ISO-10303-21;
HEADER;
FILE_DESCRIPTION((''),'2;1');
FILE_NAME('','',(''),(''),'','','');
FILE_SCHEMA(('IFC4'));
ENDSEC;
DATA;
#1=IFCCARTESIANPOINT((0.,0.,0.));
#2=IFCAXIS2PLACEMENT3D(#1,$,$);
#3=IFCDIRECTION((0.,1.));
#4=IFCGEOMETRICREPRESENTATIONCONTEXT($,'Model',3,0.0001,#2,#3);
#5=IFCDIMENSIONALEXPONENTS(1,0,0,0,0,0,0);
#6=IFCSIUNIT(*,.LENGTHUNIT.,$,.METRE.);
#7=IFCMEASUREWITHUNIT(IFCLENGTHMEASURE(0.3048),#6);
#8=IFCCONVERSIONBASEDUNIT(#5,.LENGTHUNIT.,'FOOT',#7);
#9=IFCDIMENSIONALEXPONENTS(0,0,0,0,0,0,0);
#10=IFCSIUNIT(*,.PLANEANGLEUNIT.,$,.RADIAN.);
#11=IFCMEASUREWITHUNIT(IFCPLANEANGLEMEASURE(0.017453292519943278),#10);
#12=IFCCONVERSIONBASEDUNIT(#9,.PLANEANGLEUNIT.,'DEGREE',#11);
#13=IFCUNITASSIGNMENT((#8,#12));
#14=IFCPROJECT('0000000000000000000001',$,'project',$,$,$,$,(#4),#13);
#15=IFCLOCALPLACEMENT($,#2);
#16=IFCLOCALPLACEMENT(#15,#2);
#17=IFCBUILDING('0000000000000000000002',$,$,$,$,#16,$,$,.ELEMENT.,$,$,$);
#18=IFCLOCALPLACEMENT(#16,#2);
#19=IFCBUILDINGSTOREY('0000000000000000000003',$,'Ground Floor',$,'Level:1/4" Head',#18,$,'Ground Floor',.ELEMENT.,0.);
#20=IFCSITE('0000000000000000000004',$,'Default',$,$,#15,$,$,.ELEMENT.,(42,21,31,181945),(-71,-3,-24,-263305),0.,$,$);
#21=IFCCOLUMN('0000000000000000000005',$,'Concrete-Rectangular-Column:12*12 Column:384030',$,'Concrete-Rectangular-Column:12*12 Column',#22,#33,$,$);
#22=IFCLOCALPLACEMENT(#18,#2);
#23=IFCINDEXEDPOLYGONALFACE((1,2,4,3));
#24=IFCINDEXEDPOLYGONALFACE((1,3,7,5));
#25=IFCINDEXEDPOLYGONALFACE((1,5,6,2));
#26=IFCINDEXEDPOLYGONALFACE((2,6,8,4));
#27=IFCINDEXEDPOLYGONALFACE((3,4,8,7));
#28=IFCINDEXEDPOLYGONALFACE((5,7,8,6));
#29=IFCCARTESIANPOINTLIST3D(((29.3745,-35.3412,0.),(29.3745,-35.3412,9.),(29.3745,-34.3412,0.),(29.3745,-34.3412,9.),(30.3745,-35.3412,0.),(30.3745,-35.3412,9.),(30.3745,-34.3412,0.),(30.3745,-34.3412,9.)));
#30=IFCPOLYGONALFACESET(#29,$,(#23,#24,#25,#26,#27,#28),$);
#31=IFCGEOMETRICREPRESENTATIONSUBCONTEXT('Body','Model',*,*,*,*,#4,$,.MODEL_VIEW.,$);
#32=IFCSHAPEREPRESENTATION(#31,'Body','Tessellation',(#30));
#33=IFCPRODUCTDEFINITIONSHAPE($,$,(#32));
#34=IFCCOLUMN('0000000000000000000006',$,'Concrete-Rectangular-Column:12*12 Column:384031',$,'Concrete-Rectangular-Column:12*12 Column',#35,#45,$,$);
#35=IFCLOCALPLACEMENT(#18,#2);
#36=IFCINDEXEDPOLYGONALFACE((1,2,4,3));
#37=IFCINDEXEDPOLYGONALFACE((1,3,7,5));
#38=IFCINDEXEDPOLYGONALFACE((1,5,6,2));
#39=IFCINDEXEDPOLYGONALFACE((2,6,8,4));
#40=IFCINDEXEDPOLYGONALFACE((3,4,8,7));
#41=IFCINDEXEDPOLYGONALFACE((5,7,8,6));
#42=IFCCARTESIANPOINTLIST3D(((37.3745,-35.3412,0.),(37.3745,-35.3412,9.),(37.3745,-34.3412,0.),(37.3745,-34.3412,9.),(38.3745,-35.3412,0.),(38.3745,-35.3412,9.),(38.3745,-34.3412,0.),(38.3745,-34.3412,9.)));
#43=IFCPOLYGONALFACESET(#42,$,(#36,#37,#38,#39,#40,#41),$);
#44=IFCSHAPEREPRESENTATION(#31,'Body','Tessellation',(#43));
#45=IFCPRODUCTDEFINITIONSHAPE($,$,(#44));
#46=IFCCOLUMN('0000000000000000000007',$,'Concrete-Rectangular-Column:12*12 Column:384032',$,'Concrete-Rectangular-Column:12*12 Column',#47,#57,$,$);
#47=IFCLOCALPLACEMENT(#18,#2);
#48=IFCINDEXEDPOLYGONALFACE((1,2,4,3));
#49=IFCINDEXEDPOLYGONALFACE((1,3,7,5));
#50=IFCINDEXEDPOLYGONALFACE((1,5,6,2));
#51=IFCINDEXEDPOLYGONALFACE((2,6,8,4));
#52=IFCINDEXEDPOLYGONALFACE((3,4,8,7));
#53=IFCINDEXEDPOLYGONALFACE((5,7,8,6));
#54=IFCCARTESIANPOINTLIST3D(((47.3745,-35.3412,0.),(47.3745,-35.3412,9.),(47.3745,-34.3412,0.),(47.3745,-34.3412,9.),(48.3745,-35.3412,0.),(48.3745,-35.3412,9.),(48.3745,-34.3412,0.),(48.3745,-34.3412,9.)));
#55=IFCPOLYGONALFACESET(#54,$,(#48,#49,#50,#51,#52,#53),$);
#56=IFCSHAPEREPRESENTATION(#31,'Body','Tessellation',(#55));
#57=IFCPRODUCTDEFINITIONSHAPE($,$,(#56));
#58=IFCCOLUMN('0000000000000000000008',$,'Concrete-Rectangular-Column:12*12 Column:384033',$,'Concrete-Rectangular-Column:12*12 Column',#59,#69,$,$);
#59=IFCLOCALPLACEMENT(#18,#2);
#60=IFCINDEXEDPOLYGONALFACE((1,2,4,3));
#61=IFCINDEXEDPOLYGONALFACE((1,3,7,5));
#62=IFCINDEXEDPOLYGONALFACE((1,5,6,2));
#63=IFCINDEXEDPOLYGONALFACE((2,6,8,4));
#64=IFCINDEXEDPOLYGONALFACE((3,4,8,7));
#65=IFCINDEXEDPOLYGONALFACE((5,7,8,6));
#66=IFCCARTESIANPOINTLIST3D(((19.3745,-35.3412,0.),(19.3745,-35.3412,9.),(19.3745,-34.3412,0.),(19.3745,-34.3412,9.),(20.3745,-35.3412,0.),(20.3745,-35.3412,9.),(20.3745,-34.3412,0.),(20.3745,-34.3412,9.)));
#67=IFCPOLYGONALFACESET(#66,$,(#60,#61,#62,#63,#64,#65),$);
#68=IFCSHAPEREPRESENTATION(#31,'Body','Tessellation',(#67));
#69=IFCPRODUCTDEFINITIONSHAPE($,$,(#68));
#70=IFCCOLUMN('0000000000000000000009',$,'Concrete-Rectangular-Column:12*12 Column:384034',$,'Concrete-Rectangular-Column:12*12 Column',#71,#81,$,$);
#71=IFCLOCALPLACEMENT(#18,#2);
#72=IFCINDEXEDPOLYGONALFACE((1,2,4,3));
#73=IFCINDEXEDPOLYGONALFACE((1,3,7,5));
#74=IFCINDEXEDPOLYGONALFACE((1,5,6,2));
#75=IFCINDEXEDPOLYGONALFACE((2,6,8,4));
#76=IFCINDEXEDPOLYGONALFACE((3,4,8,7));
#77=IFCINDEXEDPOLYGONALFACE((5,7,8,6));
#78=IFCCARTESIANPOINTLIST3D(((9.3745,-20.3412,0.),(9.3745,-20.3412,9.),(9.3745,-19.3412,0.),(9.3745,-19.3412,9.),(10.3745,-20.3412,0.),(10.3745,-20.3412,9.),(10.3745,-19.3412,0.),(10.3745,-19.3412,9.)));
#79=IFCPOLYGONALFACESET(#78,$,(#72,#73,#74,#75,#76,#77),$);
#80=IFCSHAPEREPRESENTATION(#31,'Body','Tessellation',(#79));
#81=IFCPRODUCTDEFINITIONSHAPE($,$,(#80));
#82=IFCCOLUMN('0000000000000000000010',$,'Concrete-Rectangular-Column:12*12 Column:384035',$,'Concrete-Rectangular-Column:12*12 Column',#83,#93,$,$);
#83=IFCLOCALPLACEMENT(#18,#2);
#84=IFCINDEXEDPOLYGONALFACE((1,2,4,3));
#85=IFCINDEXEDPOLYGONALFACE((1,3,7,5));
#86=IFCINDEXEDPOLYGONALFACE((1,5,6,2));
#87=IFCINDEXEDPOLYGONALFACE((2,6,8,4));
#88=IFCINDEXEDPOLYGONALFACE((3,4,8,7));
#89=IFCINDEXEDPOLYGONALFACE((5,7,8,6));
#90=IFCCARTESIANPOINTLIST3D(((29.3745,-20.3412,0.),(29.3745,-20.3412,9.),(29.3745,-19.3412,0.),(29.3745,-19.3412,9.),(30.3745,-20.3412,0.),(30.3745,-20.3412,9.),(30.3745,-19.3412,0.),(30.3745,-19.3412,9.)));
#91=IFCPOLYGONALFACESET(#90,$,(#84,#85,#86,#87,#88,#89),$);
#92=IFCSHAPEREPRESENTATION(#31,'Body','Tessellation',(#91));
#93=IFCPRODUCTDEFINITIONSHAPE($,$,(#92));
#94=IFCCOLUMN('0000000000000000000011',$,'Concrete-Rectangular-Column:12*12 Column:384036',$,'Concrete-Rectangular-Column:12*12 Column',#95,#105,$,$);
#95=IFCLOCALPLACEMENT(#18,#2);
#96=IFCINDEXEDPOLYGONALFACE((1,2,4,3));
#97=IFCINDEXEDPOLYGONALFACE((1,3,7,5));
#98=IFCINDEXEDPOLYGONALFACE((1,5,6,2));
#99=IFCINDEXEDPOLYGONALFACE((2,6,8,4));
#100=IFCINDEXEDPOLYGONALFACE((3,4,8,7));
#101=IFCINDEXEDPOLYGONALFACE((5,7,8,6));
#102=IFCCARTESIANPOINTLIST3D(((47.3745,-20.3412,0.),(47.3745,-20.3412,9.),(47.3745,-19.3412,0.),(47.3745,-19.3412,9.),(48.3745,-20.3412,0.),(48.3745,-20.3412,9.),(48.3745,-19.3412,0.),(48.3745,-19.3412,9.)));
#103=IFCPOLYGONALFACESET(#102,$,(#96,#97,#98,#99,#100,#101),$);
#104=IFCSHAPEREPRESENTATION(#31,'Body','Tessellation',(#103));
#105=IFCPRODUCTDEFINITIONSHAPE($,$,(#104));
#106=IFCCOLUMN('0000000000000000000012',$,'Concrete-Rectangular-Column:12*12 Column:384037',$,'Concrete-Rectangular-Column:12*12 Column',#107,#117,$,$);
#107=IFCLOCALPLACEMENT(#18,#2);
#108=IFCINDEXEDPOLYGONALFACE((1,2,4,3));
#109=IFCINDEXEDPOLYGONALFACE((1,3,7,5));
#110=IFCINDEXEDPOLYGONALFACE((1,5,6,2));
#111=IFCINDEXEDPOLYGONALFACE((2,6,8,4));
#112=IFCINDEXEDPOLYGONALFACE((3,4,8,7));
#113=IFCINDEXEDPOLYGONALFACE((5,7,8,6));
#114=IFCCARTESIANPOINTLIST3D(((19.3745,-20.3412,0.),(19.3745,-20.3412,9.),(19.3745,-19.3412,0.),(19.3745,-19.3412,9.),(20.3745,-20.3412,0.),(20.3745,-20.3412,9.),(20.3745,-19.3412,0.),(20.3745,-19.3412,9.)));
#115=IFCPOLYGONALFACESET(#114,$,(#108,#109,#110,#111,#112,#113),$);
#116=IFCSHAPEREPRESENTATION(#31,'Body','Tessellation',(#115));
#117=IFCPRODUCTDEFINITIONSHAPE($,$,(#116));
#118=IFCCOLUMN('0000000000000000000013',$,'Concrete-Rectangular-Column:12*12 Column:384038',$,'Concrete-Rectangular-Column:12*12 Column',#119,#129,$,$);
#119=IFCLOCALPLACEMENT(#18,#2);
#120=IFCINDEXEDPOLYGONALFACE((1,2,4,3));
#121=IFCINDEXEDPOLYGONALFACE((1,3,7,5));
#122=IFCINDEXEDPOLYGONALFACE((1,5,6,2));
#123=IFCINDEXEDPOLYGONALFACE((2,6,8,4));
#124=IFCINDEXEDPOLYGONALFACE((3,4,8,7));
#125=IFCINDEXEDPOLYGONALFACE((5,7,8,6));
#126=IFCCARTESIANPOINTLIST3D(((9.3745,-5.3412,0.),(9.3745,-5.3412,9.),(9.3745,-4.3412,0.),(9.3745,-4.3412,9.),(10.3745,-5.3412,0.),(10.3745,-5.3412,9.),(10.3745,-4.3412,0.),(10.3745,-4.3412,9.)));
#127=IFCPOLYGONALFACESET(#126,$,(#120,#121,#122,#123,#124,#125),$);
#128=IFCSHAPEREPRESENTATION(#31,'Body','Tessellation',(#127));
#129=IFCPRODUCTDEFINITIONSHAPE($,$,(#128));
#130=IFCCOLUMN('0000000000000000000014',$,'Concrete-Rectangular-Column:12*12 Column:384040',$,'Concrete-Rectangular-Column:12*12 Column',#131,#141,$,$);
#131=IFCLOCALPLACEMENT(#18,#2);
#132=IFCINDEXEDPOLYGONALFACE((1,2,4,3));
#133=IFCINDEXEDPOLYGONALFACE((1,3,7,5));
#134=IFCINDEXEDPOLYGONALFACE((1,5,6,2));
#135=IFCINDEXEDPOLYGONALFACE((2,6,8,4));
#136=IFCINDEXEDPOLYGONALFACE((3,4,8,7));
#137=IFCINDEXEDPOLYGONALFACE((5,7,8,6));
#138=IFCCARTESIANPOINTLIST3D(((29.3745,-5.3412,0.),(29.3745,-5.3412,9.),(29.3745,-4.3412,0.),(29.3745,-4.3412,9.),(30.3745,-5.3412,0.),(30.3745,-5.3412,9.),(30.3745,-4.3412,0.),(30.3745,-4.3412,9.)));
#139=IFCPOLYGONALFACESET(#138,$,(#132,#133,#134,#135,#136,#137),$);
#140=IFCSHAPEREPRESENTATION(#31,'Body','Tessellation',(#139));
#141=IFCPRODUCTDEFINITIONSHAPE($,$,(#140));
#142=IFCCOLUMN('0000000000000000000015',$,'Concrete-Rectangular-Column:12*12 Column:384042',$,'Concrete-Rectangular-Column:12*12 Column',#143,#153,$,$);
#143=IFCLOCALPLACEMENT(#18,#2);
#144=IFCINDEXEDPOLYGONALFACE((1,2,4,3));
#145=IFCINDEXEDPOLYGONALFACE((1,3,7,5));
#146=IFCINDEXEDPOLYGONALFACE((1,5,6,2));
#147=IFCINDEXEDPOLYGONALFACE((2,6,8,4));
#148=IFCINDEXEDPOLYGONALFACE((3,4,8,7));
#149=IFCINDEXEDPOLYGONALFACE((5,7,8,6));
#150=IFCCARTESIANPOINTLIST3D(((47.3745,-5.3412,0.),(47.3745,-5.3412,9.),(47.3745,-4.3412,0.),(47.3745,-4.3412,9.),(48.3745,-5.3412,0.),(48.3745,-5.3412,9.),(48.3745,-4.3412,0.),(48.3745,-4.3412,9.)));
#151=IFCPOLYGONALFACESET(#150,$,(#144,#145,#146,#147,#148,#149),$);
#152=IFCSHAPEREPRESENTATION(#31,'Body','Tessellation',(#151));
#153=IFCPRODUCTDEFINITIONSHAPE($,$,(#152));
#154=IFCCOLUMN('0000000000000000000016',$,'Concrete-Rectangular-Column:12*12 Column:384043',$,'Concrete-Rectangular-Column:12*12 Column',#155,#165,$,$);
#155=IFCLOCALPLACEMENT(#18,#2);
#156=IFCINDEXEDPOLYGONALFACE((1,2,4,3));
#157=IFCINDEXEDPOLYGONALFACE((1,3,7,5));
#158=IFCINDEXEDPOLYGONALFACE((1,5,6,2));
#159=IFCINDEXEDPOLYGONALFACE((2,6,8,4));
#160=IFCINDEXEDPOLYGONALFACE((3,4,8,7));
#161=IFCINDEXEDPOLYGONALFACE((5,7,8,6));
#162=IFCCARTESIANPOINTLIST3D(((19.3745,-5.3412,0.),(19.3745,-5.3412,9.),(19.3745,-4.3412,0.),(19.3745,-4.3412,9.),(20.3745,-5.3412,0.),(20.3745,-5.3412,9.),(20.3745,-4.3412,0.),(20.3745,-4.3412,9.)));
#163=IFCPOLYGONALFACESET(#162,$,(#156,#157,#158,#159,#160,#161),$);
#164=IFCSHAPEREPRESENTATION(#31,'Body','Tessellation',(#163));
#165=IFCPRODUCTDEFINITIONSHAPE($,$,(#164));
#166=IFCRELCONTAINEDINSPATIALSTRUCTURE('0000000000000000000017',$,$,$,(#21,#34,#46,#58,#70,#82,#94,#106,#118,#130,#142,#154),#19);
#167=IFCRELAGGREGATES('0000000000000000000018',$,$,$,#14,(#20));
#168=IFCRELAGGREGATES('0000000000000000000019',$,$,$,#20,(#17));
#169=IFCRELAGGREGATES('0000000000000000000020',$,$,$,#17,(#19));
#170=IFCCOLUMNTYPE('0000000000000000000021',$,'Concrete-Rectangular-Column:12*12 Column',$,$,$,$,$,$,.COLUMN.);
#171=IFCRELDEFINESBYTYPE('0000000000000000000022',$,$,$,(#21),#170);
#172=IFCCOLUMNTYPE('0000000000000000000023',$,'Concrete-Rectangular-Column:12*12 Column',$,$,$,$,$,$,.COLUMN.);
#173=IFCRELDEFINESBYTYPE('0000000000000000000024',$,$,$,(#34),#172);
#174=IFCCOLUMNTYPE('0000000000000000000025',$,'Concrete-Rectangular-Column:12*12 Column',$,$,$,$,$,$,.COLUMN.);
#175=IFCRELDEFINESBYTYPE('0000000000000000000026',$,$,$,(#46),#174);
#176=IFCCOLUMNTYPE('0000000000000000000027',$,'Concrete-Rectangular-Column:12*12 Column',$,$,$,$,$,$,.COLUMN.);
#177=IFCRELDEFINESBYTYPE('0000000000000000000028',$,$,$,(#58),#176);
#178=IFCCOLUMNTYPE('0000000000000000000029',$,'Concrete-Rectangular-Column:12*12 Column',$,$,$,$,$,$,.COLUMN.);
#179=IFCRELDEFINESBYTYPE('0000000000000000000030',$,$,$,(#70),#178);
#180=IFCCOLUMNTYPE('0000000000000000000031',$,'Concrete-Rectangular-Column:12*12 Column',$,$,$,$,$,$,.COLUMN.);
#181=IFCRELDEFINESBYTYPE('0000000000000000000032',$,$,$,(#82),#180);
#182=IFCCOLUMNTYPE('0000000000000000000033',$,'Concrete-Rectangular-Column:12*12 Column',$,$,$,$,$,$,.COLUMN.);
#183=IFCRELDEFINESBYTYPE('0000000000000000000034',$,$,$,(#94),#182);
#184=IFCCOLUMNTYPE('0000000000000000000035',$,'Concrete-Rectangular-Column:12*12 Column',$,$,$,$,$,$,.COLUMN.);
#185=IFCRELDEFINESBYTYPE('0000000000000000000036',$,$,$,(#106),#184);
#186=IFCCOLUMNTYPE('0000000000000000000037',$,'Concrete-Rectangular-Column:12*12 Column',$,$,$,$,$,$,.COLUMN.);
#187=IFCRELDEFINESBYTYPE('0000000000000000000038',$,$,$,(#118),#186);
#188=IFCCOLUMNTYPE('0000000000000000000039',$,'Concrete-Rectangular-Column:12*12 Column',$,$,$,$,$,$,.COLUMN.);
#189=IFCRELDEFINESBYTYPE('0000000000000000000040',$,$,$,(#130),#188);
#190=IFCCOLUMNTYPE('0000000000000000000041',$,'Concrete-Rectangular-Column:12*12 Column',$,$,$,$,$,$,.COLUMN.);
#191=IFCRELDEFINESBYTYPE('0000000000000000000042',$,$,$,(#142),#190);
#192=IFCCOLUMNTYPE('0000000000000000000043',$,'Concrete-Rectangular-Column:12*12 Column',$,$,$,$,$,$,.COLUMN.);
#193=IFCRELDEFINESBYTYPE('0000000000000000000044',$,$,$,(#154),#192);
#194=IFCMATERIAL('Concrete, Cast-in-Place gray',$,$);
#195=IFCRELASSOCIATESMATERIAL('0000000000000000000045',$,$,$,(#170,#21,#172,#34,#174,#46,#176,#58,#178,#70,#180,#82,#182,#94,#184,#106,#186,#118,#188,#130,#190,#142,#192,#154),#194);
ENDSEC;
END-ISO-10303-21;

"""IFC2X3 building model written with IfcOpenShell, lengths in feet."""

from ifc_helpers import new_model, entity, si_unit, converted_unit, direction, frame, frame_2d, origin, origin_2d_with_axis, place, context, subcontext, project, spatial, rectangle, extrude, source, transform, mapped, material, type_object, type_shapes, element, save


model = new_model("IFC2X3")

# Units and contexts
model_context = context("Model", 3, precision=0.0001, world=origin(), true_north=direction((0.0, 1.0)))
body_context = subcontext(model_context, "Body", "Model", "MODEL_VIEW")
ifc_project = project(units=[converted_unit("LENGTHUNIT", "FOOT", entity("IfcLengthMeasure", 0.3048), si_unit("LENGTHUNIT", "METRE"), dimensions=[1, 0, 0, 0, 0, 0, 0]), converted_unit("PLANEANGLEUNIT", "DEGREE", entity("IfcPlaneAngleMeasure", 0.017453292519943278), si_unit("PLANEANGLEUNIT", "RADIAN"), dimensions=[0, 0, 0, 0, 0, 0, 0])], contexts=[model_context])

# Site, building, storey
site_placement = place(None, origin())
site = spatial("IfcSite", under=ifc_project, at=site_placement, Name="Default", CompositionType="ELEMENT", RefLatitude=(42, 21, 31, 181945), RefLongitude=(-71, -3, -24, -263305), RefElevation=0.0)
building_placement = place(site_placement, origin())
building = spatial("IfcBuilding", under=site, at=building_placement, CompositionType="ELEMENT")
storey_placement = place(building_placement, origin())
storey = spatial("IfcBuildingStorey", under=building, at=storey_placement, Name="Ground Floor", ObjectType="Level:1/4\" Head", LongName="Ground Floor", CompositionType="ELEMENT", Elevation=0.0)

# Columns
ifc_material_1 = material(Name="Concrete, Cast-in-Place gray")
column_type_1 = type_object("IfcColumnType", Name="Concrete-Rectangular-Column:12*12 Column", PredefinedType="COLUMN", material=ifc_material_1)
shared_shape_1 = source(origin(), body_context, "Body", "SweptSolid", [
    extrude(rectangle(XDim=1.0, YDim=1.0, at=frame_2d((0.0, 0.0), x_axis=(1.0, 0.0))), frame((29.8745, -34.8412, 0.0), z_axis=(0.0, 0.0, 1.0), x_axis=(-1.0, 0.0, 0.0)), (0.0, 0.0, 1.0), 9.0),
])
type_shapes(column_type_1, [shared_shape_1])
column_1_placement = place(storey_placement, origin())
element("IfcColumn", 1, at=column_1_placement, inside=storey, type_object=column_type_1, material=ifc_material_1, Name="Concrete-Rectangular-Column:12*12 Column:384030", ObjectType="Concrete-Rectangular-Column:12*12 Column", context=body_context, shape_type="MappedRepresentation", body=[
    mapped(shared_shape_1, transform((0.0, 0.0, 0.0), scale=1.0)),
])
column_type_2 = type_object("IfcColumnType", Name="Concrete-Rectangular-Column:12*12 Column", PredefinedType="COLUMN", material=ifc_material_1)
shared_shape_2 = source(origin(), body_context, "Body", "SweptSolid", [
    extrude(rectangle(XDim=1.0, YDim=1.0, at=origin_2d_with_axis()), frame((37.8745, -34.8412, 0.0), z_axis=(0.0, 0.0, 1.0), x_axis=(-1.0, 0.0, 0.0)), (0.0, 0.0, 1.0), 9.0),
])
type_shapes(column_type_2, [shared_shape_2])
column_2_placement = place(storey_placement, origin())
element("IfcColumn", 2, at=column_2_placement, inside=storey, type_object=column_type_2, material=ifc_material_1, Name="Concrete-Rectangular-Column:12*12 Column:384031", ObjectType="Concrete-Rectangular-Column:12*12 Column", context=body_context, shape_type="MappedRepresentation", body=[
    mapped(shared_shape_2, transform((0.0, 0.0, 0.0), scale=1.0)),
])
column_type_3 = type_object("IfcColumnType", Name="Concrete-Rectangular-Column:12*12 Column", PredefinedType="COLUMN", material=ifc_material_1)
shared_shape_3 = source(origin(), body_context, "Body", "SweptSolid", [
    extrude(rectangle(XDim=1.0, YDim=1.0, at=origin_2d_with_axis()), frame((47.8745, -34.8412, 0.0), z_axis=(0.0, 0.0, 1.0), x_axis=(-1.0, 0.0, 0.0)), (0.0, 0.0, 1.0), 9.0),
])
type_shapes(column_type_3, [shared_shape_3])
column_3_placement = place(storey_placement, origin())
element("IfcColumn", 3, at=column_3_placement, inside=storey, type_object=column_type_3, material=ifc_material_1, Name="Concrete-Rectangular-Column:12*12 Column:384032", ObjectType="Concrete-Rectangular-Column:12*12 Column", context=body_context, shape_type="MappedRepresentation", body=[
    mapped(shared_shape_3, transform((0.0, 0.0, 0.0), scale=1.0)),
])
column_type_4 = type_object("IfcColumnType", Name="Concrete-Rectangular-Column:12*12 Column", PredefinedType="COLUMN", material=ifc_material_1)
shared_shape_4 = source(origin(), body_context, "Body", "SweptSolid", [
    extrude(rectangle(XDim=1.0, YDim=1.0, at=frame_2d((0.0, 0.0), x_axis=(1.0, 0.0))), frame((19.8745, -34.8412, 0.0), z_axis=(0.0, 0.0, 1.0), x_axis=(-1.0, 0.0, 0.0)), (0.0, 0.0, 1.0), 9.0),
])
type_shapes(column_type_4, [shared_shape_4])
column_4_placement = place(storey_placement, origin())
element("IfcColumn", 4, at=column_4_placement, inside=storey, type_object=column_type_4, material=ifc_material_1, Name="Concrete-Rectangular-Column:12*12 Column:384033", ObjectType="Concrete-Rectangular-Column:12*12 Column", context=body_context, shape_type="MappedRepresentation", body=[
    mapped(shared_shape_4, transform((0.0, 0.0, 0.0), scale=1.0)),
])
column_type_5 = type_object("IfcColumnType", Name="Concrete-Rectangular-Column:12*12 Column", PredefinedType="COLUMN", material=ifc_material_1)
shared_shape_5 = source(origin(), body_context, "Body", "SweptSolid", [
    extrude(rectangle(XDim=1.0, YDim=1.0, at=frame_2d((0.0, 0.0), x_axis=(1.0, 0.0))), frame((9.8745, -19.8412, 0.0), z_axis=(0.0, 0.0, 1.0), x_axis=(-1.0, 0.0, 0.0)), (0.0, 0.0, 1.0), 9.0),
])
type_shapes(column_type_5, [shared_shape_5])
column_5_placement = place(storey_placement, origin())
element("IfcColumn", 5, at=column_5_placement, inside=storey, type_object=column_type_5, material=ifc_material_1, Name="Concrete-Rectangular-Column:12*12 Column:384034", ObjectType="Concrete-Rectangular-Column:12*12 Column", context=body_context, shape_type="MappedRepresentation", body=[
    mapped(shared_shape_5, transform((0.0, 0.0, 0.0), scale=1.0)),
])
column_type_6 = type_object("IfcColumnType", Name="Concrete-Rectangular-Column:12*12 Column", PredefinedType="COLUMN", material=ifc_material_1)
shared_shape_6 = source(origin(), body_context, "Body", "SweptSolid", [
    extrude(rectangle(XDim=1.0, YDim=1.0, at=frame_2d((0.0, 0.0), x_axis=(1.0, 0.0))), frame((29.8745, -19.8412, 0.0), z_axis=(0.0, 0.0, 1.0), x_axis=(-1.0, 0.0, 0.0)), (0.0, 0.0, 1.0), 9.0),
])
type_shapes(column_type_6, [shared_shape_6])
column_6_placement = place(storey_placement, origin())
element("IfcColumn", 6, at=column_6_placement, inside=storey, type_object=column_type_6, material=ifc_material_1, Name="Concrete-Rectangular-Column:12*12 Column:384035", ObjectType="Concrete-Rectangular-Column:12*12 Column", context=body_context, shape_type="MappedRepresentation", body=[
    mapped(shared_shape_6, transform((0.0, 0.0, 0.0), scale=1.0)),
])
column_type_7 = type_object("IfcColumnType", Name="Concrete-Rectangular-Column:12*12 Column", PredefinedType="COLUMN", material=ifc_material_1)
shared_shape_7 = source(origin(), body_context, "Body", "SweptSolid", [
    extrude(rectangle(XDim=1.0, YDim=1.0, at=frame_2d((0.0, 0.0), x_axis=(1.0, 0.0))), frame((47.8745, -19.8412, 0.0), z_axis=(0.0, 0.0, 1.0), x_axis=(-1.0, 0.0, 0.0)), (0.0, 0.0, 1.0), 9.0),
])
type_shapes(column_type_7, [shared_shape_7])
column_7_placement = place(storey_placement, origin())
element("IfcColumn", 7, at=column_7_placement, inside=storey, type_object=column_type_7, material=ifc_material_1, Name="Concrete-Rectangular-Column:12*12 Column:384036", ObjectType="Concrete-Rectangular-Column:12*12 Column", context=body_context, shape_type="MappedRepresentation", body=[
    mapped(shared_shape_7, transform((0.0, 0.0, 0.0), scale=1.0)),
])
column_type_8 = type_object("IfcColumnType", Name="Concrete-Rectangular-Column:12*12 Column", PredefinedType="COLUMN", material=ifc_material_1)
shared_shape_8 = source(origin(), body_context, "Body", "SweptSolid", [
    extrude(rectangle(XDim=1.0, YDim=1.0, at=frame_2d((0.0, 0.0), x_axis=(1.0, 0.0))), frame((19.8745, -19.8412, 0.0), z_axis=(0.0, 0.0, 1.0), x_axis=(-1.0, 0.0, 0.0)), (0.0, 0.0, 1.0), 9.0),
])
type_shapes(column_type_8, [shared_shape_8])
column_8_placement = place(storey_placement, origin())
element("IfcColumn", 8, at=column_8_placement, inside=storey, type_object=column_type_8, material=ifc_material_1, Name="Concrete-Rectangular-Column:12*12 Column:384037", ObjectType="Concrete-Rectangular-Column:12*12 Column", context=body_context, shape_type="MappedRepresentation", body=[
    mapped(shared_shape_8, transform((0.0, 0.0, 0.0), scale=1.0)),
])
column_type_9 = type_object("IfcColumnType", Name="Concrete-Rectangular-Column:12*12 Column", PredefinedType="COLUMN", material=ifc_material_1)
shared_shape_9 = source(origin(), body_context, "Body", "SweptSolid", [
    extrude(rectangle(XDim=1.0, YDim=1.0, at=origin_2d_with_axis()), frame((9.8745, -4.8412, 0.0), z_axis=(0.0, 0.0, 1.0), x_axis=(-1.0, 0.0, 0.0)), (0.0, 0.0, 1.0), 9.0),
])
type_shapes(column_type_9, [shared_shape_9])
column_9_placement = place(storey_placement, origin())
element("IfcColumn", 9, at=column_9_placement, inside=storey, type_object=column_type_9, material=ifc_material_1, Name="Concrete-Rectangular-Column:12*12 Column:384038", ObjectType="Concrete-Rectangular-Column:12*12 Column", context=body_context, shape_type="MappedRepresentation", body=[
    mapped(shared_shape_9, transform((0.0, 0.0, 0.0), scale=1.0)),
])
column_type_10 = type_object("IfcColumnType", Name="Concrete-Rectangular-Column:12*12 Column", PredefinedType="COLUMN", material=ifc_material_1)
shared_shape_10 = source(origin(), body_context, "Body", "SweptSolid", [
    extrude(rectangle(XDim=1.0, YDim=1.0, at=frame_2d((0.0, 0.0), x_axis=(1.0, 0.0))), frame((29.8745, -4.8412, 0.0), z_axis=(0.0, 0.0, 1.0), x_axis=(-1.0, 0.0, 0.0)), (0.0, 0.0, 1.0), 9.0),
])
type_shapes(column_type_10, [shared_shape_10])
column_10_placement = place(storey_placement, origin())
element("IfcColumn", 10, at=column_10_placement, inside=storey, type_object=column_type_10, material=ifc_material_1, Name="Concrete-Rectangular-Column:12*12 Column:384040", ObjectType="Concrete-Rectangular-Column:12*12 Column", context=body_context, shape_type="MappedRepresentation", body=[
    mapped(shared_shape_10, transform((0.0, 0.0, 0.0), scale=1.0)),
])
column_type_11 = type_object("IfcColumnType", Name="Concrete-Rectangular-Column:12*12 Column", PredefinedType="COLUMN", material=ifc_material_1)
shared_shape_11 = source(origin(), body_context, "Body", "SweptSolid", [
    extrude(rectangle(XDim=1.0, YDim=1.0, at=frame_2d((0.0, 0.0), x_axis=(1.0, 0.0))), frame((47.8745, -4.8412, 0.0), z_axis=(0.0, 0.0, 1.0), x_axis=(-1.0, 0.0, 0.0)), (0.0, 0.0, 1.0), 9.0),
])
type_shapes(column_type_11, [shared_shape_11])
column_11_placement = place(storey_placement, origin())
element("IfcColumn", 11, at=column_11_placement, inside=storey, type_object=column_type_11, material=ifc_material_1, Name="Concrete-Rectangular-Column:12*12 Column:384042", ObjectType="Concrete-Rectangular-Column:12*12 Column", context=body_context, shape_type="MappedRepresentation", body=[
    mapped(shared_shape_11, transform((0.0, 0.0, 0.0), scale=1.0)),
])
column_type_12 = type_object("IfcColumnType", Name="Concrete-Rectangular-Column:12*12 Column", PredefinedType="COLUMN", material=ifc_material_1)
shared_shape_12 = source(origin(), body_context, "Body", "SweptSolid", [
    extrude(rectangle(XDim=1.0, YDim=1.0, at=frame_2d((0.0, 0.0), x_axis=(1.0, 0.0))), frame((19.8745, -4.8412, 0.0), z_axis=(0.0, 0.0, 1.0), x_axis=(-1.0, 0.0, 0.0)), (0.0, 0.0, 1.0), 9.0),
])
type_shapes(column_type_12, [shared_shape_12])
column_12_placement = place(storey_placement, origin())
element("IfcColumn", 12, at=column_12_placement, inside=storey, type_object=column_type_12, material=ifc_material_1, Name="Concrete-Rectangular-Column:12*12 Column:384043", ObjectType="Concrete-Rectangular-Column:12*12 Column", context=body_context, shape_type="MappedRepresentation", body=[
    mapped(shared_shape_12, transform((0.0, 0.0, 0.0), scale=1.0)),
])

save(model, "model.ifc")
